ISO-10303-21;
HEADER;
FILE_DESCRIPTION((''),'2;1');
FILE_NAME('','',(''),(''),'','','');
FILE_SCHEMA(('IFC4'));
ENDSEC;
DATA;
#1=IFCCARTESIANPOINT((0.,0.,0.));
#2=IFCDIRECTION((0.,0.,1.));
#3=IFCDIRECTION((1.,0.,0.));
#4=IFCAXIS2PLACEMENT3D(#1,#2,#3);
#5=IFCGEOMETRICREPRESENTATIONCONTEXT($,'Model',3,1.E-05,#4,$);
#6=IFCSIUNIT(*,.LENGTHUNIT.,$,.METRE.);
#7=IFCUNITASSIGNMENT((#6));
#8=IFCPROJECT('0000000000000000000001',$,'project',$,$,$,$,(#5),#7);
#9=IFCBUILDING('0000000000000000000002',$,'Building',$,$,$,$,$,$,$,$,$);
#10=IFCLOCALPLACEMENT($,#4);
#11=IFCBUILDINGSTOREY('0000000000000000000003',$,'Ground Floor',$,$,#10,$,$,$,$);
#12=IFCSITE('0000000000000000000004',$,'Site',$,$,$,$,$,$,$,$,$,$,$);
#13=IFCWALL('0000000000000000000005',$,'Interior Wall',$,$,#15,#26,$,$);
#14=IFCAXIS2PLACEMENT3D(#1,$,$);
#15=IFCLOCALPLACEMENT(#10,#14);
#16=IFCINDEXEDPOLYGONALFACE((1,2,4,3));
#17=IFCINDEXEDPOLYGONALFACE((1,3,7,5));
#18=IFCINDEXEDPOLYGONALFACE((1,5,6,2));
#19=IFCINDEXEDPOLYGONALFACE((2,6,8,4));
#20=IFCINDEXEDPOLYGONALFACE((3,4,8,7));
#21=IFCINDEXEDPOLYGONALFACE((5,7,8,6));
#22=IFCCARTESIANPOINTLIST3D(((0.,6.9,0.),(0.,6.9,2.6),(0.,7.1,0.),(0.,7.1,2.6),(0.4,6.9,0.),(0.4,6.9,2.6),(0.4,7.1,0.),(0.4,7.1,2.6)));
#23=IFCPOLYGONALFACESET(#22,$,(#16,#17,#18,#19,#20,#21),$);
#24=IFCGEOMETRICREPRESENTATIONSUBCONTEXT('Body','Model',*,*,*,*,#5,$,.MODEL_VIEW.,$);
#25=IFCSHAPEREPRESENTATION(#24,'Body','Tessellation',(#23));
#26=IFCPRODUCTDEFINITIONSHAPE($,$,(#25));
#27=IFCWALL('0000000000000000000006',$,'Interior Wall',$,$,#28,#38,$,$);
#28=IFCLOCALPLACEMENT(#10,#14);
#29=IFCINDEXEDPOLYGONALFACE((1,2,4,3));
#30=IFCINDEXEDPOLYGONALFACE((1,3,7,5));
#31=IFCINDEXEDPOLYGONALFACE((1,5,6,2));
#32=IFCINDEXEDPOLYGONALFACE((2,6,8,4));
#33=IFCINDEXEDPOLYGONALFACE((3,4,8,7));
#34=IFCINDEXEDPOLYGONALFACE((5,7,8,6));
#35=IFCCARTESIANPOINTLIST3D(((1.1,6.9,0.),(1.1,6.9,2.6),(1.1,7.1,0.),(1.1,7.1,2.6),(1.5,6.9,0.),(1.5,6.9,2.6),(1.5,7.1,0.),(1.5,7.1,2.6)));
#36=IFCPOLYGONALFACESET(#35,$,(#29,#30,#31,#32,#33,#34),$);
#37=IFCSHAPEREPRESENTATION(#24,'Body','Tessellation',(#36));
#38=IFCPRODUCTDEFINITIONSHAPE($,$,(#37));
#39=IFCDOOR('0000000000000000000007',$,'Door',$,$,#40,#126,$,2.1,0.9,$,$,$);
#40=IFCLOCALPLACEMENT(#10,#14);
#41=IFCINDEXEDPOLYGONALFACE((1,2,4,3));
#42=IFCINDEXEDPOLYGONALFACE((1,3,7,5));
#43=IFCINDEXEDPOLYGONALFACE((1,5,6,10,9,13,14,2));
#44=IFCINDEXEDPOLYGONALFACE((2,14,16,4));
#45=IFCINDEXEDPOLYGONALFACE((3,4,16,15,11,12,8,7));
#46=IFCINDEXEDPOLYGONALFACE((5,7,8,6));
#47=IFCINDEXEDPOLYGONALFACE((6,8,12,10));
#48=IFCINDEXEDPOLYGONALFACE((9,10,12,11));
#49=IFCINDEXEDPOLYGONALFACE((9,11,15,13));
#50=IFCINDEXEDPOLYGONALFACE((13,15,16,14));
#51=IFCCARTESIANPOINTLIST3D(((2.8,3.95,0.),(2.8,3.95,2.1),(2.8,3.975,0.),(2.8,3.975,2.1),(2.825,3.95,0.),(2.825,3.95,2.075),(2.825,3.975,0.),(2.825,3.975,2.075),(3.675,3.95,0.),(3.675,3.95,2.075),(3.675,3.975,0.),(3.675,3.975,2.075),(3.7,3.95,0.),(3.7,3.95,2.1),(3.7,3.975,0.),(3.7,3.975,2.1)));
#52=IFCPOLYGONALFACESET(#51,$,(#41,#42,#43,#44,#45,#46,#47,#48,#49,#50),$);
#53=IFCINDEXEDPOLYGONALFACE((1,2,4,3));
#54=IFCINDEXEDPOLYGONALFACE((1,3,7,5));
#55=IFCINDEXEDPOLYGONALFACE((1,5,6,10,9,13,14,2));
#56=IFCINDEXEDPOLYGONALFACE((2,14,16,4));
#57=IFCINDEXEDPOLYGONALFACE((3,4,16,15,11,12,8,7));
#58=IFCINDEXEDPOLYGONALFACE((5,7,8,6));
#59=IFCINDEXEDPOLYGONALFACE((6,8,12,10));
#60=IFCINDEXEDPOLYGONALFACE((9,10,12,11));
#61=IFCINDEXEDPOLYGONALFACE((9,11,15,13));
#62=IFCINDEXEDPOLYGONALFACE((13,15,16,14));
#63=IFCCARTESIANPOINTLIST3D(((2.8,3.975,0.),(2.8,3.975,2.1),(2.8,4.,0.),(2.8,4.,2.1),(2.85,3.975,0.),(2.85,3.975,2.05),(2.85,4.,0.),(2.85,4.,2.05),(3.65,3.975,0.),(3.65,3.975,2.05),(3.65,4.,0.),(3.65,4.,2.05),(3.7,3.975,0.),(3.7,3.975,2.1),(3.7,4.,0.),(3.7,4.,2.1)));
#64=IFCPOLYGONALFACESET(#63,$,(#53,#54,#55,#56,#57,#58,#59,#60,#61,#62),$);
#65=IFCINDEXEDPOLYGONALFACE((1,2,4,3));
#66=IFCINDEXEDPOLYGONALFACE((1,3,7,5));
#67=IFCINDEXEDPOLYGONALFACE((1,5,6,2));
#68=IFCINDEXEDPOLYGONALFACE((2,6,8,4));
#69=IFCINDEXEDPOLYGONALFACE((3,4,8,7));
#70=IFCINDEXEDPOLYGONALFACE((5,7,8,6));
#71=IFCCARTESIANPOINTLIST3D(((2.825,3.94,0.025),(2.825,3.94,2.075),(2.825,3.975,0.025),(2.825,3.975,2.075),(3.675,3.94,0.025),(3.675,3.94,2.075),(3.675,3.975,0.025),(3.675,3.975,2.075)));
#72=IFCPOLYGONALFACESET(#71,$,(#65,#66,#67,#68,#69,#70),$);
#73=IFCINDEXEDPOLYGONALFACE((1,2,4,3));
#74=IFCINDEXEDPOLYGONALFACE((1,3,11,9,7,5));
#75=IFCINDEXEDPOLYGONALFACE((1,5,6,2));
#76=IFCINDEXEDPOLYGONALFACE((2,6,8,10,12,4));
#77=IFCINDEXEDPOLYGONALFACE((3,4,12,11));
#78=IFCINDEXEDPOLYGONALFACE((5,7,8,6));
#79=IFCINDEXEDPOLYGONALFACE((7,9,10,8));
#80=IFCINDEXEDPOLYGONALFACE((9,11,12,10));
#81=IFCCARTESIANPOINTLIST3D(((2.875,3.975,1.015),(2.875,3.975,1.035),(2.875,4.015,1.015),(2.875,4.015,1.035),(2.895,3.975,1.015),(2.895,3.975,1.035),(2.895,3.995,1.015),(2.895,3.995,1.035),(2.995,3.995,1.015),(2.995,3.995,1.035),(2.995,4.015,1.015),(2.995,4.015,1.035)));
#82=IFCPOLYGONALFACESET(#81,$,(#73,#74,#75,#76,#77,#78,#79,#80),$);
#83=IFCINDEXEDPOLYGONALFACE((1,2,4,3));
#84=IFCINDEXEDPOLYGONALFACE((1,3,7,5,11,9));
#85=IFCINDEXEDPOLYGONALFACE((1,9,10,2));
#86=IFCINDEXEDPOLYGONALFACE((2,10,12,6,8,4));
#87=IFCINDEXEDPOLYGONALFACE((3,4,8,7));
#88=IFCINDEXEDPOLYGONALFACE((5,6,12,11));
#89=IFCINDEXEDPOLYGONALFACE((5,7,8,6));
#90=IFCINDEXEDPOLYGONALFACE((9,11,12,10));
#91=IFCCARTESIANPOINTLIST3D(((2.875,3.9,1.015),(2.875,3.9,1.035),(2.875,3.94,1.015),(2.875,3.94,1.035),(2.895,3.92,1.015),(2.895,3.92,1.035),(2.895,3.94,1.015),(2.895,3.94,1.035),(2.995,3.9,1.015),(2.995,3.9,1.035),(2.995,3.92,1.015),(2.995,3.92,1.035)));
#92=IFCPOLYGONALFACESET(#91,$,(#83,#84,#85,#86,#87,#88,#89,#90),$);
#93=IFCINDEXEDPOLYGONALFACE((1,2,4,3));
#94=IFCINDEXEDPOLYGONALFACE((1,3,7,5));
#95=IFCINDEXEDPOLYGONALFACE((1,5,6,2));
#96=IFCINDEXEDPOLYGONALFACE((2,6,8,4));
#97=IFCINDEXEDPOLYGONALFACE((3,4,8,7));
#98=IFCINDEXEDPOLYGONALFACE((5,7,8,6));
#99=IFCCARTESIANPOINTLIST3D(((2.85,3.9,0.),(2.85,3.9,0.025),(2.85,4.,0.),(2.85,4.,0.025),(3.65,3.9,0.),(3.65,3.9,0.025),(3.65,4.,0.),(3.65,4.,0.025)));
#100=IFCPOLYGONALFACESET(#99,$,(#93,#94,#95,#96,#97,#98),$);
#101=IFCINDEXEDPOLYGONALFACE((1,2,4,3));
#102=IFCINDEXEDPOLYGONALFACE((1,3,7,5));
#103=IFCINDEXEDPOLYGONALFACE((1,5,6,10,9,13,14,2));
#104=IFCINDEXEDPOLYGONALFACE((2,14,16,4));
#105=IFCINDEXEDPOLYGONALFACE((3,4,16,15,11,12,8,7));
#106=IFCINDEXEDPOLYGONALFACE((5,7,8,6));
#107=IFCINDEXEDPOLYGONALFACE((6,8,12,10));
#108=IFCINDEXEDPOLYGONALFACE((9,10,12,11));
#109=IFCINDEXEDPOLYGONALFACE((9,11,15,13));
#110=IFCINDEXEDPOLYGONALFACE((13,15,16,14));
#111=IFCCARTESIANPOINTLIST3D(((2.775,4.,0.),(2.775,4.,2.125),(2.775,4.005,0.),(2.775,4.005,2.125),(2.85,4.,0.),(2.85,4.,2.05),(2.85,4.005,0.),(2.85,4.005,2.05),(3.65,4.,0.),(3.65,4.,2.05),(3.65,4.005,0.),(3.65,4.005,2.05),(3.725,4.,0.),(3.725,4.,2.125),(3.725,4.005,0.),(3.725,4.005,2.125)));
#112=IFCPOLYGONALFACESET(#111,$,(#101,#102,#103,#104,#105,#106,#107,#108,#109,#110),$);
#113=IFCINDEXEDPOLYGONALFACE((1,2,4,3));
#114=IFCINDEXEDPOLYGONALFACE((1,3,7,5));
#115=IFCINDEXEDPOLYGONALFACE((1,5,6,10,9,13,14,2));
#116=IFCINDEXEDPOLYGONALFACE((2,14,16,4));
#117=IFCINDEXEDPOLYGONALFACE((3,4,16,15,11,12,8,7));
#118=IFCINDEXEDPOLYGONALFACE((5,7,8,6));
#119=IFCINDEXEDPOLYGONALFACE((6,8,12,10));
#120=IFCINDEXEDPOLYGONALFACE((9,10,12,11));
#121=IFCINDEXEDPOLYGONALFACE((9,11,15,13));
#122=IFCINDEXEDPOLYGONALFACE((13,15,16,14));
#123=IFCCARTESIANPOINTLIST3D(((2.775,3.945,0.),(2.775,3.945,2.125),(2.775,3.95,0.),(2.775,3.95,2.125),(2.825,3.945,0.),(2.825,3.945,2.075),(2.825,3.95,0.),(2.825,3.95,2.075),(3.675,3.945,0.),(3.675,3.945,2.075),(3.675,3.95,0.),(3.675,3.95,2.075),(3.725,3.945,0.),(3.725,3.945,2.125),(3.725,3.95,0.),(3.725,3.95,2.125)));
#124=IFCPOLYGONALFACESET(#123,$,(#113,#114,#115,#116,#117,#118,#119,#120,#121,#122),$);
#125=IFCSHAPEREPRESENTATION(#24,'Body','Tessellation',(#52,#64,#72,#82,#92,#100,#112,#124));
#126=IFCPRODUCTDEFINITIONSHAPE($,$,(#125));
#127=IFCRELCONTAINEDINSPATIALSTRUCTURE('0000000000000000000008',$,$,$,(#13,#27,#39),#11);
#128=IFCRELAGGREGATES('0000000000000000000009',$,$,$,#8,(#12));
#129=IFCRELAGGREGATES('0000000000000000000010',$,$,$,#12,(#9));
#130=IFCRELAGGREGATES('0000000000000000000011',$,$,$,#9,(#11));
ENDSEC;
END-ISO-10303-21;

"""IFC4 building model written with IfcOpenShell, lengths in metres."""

from ifc_helpers import new_model, si_unit, frame, origin_with_axes, place, context, subcontext, project, spatial, line, indexed_curve, outline, extrude, element, save


model = new_model("IFC4")

# Units and contexts
model_context = context("Model", 3, precision=1e-05, world=origin_with_axes())
body_context = subcontext(model_context, "Body", "Model", "MODEL_VIEW")
ifc_project = project(units=[si_unit("LENGTHUNIT", "METRE")], contexts=[model_context])

# Site, building, storey
site = spatial("IfcSite", under=ifc_project, Name="Site")
building = spatial("IfcBuilding", under=site, Name="Building")
storey_placement = place(None, origin_with_axes())
storey = spatial("IfcBuildingStorey", under=building, at=storey_placement, Name="Ground Floor")

# Walls
wall_1_placement = place(storey_placement, frame((0.0, 7.0, 0.0), z_axis=(0.0, 0.0, 1.0), x_axis=(1.0, 0.0, 0.0)))
element("IfcWall", 1, at=wall_1_placement, inside=storey, Name="Interior Wall", context=body_context, shape_type="SweptSolid", body=[
    extrude(outline(indexed_curve([(0.0, 0.0), (0.0, 0.2), (0.4, 0.2), (0.4, 0.0), (0.0, 0.0)], self_intersect=False)), frame((0.0, -0.1, 0.0), z_axis=(0.0, 0.0, 1.0), x_axis=(1.0, 0.0, 0.0)), (0.0, 0.0, 1.0), 2.6),
])
wall_2_placement = place(storey_placement, frame((1.1, 7.0, 0.0), z_axis=(0.0, 0.0, 1.0), x_axis=(1.0, 0.0, 0.0)))
element("IfcWall", 2, at=wall_2_placement, inside=storey, Name="Interior Wall", context=body_context, shape_type="SweptSolid", body=[
    extrude(outline(indexed_curve([(0.0, 0.0), (0.0, 0.2), (0.4, 0.2), (0.4, 0.0), (0.0, 0.0)], self_intersect=False)), frame((0.0, -0.1, 0.0), z_axis=(0.0, 0.0, 1.0), x_axis=(1.0, 0.0, 0.0)), (0.0, 0.0, 1.0), 2.6),
])

# Door
door_1_placement = place(storey_placement, frame((3.7, 4.0, 0.0), z_axis=(0.0, 0.0, 1.0), x_axis=(-1.0, 0.0, 0.0)))
element("IfcDoor", 3, at=door_1_placement, inside=storey, Name="Door", OverallHeight=2.1, OverallWidth=0.9, context=body_context, shape_type="SweptSolid", body=[
    extrude(outline(indexed_curve([(0.0, 0.0), (0.0, 2.1), (0.9, 2.1), (0.9, 0.0), (0.875, 0.0), (0.875, 2.075), (0.025, 2.075), (0.025, 0.0)], segments=[line(1, 2, 3, 4, 5, 6, 7, 8, 1)])), frame((0.0, 0.025, 0.0), z_axis=(0.0, -1.0, 0.0), x_axis=(1.0, 0.0, 0.0)), (0.0, 0.0, -1.0), 0.025),
    extrude(outline(indexed_curve([(0.0, 0.0), (0.0, 2.1), (0.9, 2.1), (0.9, 0.0), (0.85, 0.0), (0.85, 2.05), (0.05, 2.05), (0.05, 0.0)], segments=[line(1, 2, 3, 4, 5, 6, 7, 8, 1)])), frame((0.0, 0.0, 0.0), z_axis=(0.0, -1.0, 0.0), x_axis=(1.0, 0.0, 0.0)), (0.0, 0.0, -1.0), 0.025),
    extrude(outline(indexed_curve([(0.0, 0.0), (0.85, 0.0), (0.85, 0.035), (0.0, 0.035)], segments=[line(1, 2, 3, 4, 1)])), frame((0.025, 0.025, 0.025), z_axis=(0.0, 0.0, 1.0), x_axis=(1.0, 0.0, 0.0)), (0.0, 0.0, 1.0), 2.05),
    extrude(outline(indexed_curve([(0.0, 0.0), (0.0, -0.04), (-0.12, -0.04), (-0.12, -0.02), (-0.02, -0.02), (-0.02, 0.0)], segments=[line(1, 2, 3, 4, 5, 6, 1)])), frame((0.825, 0.025, 1.015), z_axis=(0.0, 0.0, 1.0), x_axis=(1.0, 0.0, 0.0)), (0.0, 0.0, 1.0), 0.02),
    extrude(outline(indexed_curve([(0.0, 0.0), (0.0, 0.04), (-0.12, 0.04), (-0.12, 0.02), (-0.02, 0.02), (-0.02, 0.0)], segments=[line(1, 2, 3, 4, 5, 6, 1)])), frame((0.825, 0.06, 1.015), z_axis=(0.0, 0.0, 1.0), x_axis=(1.0, 0.0, 0.0)), (0.0, 0.0, 1.0), 0.02),
    extrude(outline(indexed_curve([(0.0, 0.0), (0.8, 0.0), (0.8, 0.1), (0.0, 0.1)], segments=[line(1, 2, 3, 4, 1)])), frame((0.05, 0.0, 0.0), z_axis=(0.0, 0.0, 1.0), x_axis=(1.0, 0.0, 0.0)), (0.0, 0.0, 1.0), 0.025),
    extrude(outline(indexed_curve([(0.0, 0.0), (0.0, 2.125), (0.95, 2.125), (0.95, 0.0), (0.875, 0.0), (0.875, 2.05), (0.075, 2.05), (0.075, 0.0)], segments=[line(1, 2, 3, 4, 5, 6, 7, 8, 1)])), frame((-0.025, -0.005, 0.0), z_axis=(0.0, -1.0, 0.0), x_axis=(1.0, 0.0, 0.0)), (0.0, 0.0, -1.0), 0.005),
    extrude(outline(indexed_curve([(0.0, 0.0), (0.0, 2.125), (0.95, 2.125), (0.95, 0.0), (0.9, 0.0), (0.9, 2.075), (0.05, 2.075), (0.05, 0.0)], segments=[line(1, 2, 3, 4, 5, 6, 7, 8, 1)])), frame((-0.025, 0.05, 0.0), z_axis=(0.0, -1.0, 0.0), x_axis=(1.0, 0.0, 0.0)), (0.0, 0.0, -1.0), 0.005),
])

save(model, "model.ifc")
